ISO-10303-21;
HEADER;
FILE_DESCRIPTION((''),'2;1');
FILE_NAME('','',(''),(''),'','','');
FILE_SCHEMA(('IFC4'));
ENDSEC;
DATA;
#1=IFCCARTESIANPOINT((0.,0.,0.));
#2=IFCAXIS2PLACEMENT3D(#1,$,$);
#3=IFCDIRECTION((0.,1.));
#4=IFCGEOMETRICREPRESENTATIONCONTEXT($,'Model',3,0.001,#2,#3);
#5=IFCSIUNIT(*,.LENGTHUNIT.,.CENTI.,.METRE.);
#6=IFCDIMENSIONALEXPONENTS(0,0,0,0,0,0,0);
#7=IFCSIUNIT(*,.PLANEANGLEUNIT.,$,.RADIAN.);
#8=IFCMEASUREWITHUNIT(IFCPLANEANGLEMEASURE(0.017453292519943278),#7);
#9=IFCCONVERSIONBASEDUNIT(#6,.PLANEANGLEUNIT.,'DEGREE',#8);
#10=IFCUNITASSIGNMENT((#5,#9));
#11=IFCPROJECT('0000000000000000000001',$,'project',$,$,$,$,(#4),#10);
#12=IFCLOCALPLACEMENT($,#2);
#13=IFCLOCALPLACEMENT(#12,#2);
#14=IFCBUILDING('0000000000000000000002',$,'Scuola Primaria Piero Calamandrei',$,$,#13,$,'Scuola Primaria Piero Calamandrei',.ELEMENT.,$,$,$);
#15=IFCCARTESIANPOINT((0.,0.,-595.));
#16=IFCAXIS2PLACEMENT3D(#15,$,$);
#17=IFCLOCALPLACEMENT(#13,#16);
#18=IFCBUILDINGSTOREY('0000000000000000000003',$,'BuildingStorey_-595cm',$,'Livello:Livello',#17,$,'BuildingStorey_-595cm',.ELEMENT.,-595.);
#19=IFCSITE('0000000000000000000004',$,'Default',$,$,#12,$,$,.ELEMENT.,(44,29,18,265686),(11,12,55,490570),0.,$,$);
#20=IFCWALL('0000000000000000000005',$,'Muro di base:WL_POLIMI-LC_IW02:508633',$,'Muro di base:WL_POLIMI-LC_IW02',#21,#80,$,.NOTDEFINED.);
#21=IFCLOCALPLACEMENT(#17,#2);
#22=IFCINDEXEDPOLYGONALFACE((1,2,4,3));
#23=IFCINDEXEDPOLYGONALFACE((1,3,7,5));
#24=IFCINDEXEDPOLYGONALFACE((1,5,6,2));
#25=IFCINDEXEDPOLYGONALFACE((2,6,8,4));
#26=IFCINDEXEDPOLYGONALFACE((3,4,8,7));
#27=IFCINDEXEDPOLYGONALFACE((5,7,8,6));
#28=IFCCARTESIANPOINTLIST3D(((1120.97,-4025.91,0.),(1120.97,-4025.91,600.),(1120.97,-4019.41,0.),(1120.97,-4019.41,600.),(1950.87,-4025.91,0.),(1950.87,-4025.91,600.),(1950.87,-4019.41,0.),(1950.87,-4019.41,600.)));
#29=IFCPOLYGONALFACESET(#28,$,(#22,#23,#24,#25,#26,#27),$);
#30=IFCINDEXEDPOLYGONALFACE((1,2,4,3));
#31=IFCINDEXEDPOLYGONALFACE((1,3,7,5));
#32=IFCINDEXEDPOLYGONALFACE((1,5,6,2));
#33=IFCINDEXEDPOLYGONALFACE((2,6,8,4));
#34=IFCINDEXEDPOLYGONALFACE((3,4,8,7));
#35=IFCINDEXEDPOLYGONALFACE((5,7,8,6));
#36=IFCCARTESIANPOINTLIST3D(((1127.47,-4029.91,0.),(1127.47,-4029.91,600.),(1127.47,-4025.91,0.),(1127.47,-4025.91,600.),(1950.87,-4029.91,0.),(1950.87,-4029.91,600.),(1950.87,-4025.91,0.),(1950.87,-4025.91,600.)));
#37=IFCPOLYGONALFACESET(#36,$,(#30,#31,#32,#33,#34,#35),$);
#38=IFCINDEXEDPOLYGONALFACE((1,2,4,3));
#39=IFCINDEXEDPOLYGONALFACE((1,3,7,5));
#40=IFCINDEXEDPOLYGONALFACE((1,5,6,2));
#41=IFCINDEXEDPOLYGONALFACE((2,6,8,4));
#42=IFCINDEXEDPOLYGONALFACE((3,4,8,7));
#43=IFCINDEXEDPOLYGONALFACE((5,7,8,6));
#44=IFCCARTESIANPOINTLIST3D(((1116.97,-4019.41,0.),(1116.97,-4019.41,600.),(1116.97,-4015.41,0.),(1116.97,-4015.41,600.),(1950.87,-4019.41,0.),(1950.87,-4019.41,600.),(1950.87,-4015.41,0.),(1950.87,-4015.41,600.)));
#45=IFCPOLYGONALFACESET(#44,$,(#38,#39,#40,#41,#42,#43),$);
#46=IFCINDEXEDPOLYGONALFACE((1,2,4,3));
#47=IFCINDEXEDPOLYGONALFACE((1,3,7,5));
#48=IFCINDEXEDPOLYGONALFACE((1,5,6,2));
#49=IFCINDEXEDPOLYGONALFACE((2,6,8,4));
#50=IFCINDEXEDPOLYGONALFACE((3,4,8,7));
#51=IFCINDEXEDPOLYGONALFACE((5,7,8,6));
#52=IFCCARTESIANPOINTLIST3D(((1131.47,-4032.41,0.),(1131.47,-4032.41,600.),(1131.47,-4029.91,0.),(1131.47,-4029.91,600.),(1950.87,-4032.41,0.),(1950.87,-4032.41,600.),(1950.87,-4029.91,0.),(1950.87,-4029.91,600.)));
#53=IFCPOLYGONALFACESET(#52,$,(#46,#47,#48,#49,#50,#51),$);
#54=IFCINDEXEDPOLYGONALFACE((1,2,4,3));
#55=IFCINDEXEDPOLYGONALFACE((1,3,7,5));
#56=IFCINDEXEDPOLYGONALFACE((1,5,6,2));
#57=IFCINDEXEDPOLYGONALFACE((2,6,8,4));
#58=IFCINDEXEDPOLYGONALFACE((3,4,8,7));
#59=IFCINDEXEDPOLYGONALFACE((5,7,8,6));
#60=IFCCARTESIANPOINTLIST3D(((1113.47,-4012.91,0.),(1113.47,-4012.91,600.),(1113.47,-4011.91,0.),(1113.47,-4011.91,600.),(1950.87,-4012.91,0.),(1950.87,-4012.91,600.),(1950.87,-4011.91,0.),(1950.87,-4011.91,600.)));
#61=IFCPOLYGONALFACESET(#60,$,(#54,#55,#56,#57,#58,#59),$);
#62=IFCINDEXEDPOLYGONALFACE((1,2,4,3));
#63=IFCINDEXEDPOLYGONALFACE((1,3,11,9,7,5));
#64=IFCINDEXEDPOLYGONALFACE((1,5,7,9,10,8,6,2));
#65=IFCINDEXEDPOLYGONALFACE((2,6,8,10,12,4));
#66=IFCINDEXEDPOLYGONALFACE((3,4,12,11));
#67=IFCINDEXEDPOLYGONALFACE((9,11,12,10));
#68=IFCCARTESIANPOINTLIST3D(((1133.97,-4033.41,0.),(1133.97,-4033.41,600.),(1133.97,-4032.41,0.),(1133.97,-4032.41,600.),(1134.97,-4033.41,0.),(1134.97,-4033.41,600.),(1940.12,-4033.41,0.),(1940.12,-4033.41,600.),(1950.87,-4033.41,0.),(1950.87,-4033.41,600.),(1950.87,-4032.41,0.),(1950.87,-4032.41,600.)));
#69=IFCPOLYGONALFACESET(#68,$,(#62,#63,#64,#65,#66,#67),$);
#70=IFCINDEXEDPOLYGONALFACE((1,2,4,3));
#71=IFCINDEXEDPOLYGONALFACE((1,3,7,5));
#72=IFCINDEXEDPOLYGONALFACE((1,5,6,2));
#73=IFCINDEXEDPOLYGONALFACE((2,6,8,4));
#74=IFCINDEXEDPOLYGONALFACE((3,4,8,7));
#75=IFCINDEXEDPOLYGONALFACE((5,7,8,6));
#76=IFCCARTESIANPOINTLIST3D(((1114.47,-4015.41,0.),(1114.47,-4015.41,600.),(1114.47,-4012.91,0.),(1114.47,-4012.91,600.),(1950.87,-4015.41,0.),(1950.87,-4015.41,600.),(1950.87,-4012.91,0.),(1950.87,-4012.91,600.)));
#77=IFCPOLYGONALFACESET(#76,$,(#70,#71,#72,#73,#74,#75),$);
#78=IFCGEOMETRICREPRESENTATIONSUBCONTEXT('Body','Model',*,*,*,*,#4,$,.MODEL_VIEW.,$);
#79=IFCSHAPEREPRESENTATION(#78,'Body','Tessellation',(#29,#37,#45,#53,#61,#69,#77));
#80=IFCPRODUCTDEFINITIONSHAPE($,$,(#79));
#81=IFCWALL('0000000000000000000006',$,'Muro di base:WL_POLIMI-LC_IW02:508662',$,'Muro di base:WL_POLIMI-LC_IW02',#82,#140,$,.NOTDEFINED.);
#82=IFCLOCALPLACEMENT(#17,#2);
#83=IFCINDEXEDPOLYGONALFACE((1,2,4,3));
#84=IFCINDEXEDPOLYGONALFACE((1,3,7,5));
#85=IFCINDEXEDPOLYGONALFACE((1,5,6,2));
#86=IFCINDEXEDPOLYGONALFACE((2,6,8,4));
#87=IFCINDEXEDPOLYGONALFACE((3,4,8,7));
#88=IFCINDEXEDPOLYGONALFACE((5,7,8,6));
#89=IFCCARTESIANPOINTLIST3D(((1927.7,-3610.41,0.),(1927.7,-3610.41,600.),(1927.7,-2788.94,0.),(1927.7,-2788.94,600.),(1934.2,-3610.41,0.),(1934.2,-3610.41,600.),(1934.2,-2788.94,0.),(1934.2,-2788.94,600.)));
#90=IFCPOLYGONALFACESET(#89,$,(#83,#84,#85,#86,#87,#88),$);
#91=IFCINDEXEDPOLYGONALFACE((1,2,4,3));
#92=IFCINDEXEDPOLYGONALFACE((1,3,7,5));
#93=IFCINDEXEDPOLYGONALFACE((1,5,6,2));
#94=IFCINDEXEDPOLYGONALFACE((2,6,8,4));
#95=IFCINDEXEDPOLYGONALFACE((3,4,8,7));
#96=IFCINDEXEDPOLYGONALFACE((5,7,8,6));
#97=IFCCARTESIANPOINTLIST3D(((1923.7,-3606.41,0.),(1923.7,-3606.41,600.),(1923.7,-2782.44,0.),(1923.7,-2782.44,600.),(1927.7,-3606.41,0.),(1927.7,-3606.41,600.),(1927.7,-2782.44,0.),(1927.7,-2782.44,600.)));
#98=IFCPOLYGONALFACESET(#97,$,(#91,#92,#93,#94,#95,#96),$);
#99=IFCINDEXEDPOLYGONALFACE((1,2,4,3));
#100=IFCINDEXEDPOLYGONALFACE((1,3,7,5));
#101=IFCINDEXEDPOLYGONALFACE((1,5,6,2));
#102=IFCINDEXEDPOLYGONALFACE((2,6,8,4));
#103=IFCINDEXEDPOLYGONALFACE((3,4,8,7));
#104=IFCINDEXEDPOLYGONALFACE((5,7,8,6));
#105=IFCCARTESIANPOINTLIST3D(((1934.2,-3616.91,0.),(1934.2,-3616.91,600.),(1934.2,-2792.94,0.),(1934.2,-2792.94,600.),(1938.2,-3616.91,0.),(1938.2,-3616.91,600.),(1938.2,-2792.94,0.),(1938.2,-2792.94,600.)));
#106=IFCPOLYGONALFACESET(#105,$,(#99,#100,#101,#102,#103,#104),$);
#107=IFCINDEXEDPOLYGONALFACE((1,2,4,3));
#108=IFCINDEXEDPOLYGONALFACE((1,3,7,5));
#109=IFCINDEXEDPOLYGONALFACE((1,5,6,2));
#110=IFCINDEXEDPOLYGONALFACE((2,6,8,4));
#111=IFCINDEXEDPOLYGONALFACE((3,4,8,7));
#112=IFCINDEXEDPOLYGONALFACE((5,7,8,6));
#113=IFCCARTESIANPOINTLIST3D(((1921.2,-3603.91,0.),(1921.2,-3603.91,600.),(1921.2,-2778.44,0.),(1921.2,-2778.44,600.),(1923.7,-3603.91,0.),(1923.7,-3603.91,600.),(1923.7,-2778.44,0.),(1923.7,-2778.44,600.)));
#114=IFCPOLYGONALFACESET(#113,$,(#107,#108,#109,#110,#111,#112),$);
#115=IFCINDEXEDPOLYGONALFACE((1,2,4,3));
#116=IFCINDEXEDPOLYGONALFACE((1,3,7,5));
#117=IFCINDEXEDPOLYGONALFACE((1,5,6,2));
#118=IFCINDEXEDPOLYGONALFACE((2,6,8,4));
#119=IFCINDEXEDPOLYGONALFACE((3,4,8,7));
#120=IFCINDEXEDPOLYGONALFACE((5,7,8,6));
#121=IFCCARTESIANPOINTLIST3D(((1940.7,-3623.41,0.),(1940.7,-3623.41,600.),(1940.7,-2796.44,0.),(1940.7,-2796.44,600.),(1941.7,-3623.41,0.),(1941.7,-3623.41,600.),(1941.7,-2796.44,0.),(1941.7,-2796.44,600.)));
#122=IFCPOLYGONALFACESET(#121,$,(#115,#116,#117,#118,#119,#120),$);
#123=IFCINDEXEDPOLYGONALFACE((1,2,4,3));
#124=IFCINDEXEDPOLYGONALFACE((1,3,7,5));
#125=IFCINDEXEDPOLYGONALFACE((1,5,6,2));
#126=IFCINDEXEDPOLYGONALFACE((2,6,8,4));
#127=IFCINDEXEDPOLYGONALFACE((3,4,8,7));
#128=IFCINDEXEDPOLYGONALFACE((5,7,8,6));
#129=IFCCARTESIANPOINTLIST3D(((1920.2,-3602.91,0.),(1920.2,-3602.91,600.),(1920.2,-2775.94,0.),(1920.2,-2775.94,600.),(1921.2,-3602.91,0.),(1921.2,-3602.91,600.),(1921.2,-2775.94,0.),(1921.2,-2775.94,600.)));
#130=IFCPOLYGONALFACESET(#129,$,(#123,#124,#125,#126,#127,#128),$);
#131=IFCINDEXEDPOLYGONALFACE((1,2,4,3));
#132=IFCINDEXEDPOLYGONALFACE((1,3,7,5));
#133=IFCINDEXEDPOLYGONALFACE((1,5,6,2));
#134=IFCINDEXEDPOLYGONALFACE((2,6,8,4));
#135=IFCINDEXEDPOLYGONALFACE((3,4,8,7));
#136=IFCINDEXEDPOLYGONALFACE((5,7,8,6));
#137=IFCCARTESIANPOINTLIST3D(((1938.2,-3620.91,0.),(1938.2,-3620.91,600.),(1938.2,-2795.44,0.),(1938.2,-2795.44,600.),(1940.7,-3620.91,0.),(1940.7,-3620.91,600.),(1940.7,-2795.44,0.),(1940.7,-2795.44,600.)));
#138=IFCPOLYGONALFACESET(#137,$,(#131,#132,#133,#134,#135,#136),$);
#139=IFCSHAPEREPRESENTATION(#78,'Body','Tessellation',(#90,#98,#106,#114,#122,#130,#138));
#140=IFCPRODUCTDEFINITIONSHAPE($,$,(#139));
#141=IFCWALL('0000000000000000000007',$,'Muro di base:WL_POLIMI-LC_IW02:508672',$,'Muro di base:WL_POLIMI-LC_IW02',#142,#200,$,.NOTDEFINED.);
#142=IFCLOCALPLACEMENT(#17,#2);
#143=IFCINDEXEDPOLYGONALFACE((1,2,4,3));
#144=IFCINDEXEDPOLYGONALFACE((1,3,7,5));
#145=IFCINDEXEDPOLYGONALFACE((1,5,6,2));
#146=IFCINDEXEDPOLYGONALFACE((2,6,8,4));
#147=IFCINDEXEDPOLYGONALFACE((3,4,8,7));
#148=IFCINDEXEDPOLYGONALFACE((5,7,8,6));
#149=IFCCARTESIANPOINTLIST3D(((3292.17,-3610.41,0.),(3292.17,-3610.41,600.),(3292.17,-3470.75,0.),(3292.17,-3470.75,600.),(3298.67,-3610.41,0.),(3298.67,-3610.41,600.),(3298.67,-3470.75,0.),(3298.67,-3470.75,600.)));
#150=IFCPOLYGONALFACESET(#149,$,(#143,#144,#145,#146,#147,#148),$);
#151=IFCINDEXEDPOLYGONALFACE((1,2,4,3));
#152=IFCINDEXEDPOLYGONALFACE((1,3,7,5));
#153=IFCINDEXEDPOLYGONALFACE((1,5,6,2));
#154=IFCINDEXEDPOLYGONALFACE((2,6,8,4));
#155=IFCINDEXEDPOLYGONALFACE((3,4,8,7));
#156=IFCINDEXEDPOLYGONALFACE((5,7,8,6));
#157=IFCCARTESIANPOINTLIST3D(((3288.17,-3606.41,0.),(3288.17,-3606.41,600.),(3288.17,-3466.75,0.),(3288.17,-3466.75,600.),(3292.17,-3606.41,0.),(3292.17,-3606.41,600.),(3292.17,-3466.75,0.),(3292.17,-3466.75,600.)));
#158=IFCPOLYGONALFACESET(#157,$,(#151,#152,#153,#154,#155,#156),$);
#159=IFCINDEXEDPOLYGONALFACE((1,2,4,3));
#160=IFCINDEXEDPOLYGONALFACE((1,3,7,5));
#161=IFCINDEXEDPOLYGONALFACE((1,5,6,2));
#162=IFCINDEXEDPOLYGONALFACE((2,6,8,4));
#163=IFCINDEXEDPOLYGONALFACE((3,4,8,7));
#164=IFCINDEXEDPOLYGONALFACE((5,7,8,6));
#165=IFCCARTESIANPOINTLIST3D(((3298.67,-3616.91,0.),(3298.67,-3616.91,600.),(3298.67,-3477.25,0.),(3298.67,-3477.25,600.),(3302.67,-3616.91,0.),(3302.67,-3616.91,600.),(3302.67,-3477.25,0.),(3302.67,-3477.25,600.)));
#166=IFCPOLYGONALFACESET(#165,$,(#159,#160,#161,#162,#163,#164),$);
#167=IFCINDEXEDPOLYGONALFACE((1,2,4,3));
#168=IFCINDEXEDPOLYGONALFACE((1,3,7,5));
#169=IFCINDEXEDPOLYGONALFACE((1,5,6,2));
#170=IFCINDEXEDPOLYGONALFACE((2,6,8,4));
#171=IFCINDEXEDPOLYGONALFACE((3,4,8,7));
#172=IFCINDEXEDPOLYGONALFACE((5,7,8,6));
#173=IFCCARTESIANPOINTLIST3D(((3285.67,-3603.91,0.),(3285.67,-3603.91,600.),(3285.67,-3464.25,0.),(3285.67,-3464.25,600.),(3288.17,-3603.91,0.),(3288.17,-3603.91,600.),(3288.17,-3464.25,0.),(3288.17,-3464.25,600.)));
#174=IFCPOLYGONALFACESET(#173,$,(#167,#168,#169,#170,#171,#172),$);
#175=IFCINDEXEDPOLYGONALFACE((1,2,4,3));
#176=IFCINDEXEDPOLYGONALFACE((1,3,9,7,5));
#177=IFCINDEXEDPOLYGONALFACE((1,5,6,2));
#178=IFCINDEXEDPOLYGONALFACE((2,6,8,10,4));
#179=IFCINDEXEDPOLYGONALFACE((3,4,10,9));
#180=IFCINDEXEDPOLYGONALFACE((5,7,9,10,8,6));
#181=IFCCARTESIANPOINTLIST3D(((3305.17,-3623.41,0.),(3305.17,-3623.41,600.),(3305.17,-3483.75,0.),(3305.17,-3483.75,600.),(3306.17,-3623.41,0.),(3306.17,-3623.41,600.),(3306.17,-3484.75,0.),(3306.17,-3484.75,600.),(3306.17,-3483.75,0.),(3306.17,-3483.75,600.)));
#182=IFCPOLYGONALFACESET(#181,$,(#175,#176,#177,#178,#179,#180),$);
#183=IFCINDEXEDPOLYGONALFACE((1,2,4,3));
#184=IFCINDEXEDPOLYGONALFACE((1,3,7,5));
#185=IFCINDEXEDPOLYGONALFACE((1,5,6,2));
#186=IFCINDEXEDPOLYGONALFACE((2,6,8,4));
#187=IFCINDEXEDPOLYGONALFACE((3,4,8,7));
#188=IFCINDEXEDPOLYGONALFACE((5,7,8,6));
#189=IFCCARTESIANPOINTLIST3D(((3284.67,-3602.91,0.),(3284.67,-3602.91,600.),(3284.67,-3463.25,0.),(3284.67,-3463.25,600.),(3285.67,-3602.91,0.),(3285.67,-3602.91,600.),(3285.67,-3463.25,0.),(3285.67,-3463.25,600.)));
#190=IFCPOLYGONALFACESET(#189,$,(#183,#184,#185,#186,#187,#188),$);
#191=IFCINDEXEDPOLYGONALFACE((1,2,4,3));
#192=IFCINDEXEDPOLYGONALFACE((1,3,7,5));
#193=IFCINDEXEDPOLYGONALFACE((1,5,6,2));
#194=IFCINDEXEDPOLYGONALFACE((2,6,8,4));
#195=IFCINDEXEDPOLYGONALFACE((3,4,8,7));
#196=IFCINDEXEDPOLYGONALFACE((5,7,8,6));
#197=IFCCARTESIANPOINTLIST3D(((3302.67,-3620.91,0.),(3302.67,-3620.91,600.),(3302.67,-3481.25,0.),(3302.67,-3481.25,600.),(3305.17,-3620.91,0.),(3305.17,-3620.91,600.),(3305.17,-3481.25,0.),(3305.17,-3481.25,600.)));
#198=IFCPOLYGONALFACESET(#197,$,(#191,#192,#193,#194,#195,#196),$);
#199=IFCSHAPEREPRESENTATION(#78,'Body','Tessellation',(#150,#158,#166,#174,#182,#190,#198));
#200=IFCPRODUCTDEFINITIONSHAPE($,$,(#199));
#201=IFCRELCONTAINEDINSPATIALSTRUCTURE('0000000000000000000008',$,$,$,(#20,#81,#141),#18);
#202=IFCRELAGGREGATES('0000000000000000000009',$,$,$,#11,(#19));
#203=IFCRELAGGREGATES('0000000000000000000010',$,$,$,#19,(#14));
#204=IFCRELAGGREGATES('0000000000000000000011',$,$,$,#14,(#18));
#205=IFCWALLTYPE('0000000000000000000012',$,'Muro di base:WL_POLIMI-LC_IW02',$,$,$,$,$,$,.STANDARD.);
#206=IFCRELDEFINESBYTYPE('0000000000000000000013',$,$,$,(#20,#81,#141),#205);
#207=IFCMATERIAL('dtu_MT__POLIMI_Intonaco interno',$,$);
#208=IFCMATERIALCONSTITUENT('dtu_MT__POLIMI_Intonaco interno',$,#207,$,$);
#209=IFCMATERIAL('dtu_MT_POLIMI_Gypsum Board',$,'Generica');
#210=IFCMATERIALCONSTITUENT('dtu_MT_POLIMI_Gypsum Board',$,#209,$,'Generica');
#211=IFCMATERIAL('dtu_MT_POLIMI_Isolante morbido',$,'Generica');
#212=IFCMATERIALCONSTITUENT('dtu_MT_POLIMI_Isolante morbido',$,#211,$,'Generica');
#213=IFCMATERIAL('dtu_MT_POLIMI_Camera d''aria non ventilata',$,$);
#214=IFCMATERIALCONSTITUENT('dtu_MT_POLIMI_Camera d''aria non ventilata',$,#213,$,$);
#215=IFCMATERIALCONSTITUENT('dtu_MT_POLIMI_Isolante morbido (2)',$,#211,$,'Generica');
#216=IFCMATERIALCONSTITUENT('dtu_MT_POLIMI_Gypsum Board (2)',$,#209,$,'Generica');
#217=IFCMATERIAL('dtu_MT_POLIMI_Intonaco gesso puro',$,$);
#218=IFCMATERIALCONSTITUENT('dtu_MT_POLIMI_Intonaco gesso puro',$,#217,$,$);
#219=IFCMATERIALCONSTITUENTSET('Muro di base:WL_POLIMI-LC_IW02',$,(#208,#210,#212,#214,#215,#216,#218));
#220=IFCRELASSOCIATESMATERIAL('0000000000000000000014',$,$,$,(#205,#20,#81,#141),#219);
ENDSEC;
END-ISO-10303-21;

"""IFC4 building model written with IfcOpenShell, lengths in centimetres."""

from ifc_helpers import new_model, entity, si_unit, converted_unit, direction, frame, origin, place, context, subcontext, project, spatial, indexed_curve, outline, extrude, material, constituent, constituent_set, type_object, element, save


model = new_model("IFC4")

# Units and contexts
model_context = context("Model", 3, precision=0.001, world=origin(), true_north=direction((0.0, 1.0)))
body_context = subcontext(model_context, "Body", "Model", "MODEL_VIEW")
ifc_project = project(units=[si_unit("LENGTHUNIT", "METRE", prefix="CENTI"), converted_unit("PLANEANGLEUNIT", "DEGREE", entity("IfcPlaneAngleMeasure", 0.017453292519943278), si_unit("PLANEANGLEUNIT", "RADIAN"), dimensions=[0, 0, 0, 0, 0, 0, 0])], contexts=[model_context])

# Site, building, storey
site_placement = place(None, origin())
site = spatial("IfcSite", under=ifc_project, at=site_placement, Name="Default", CompositionType="ELEMENT", RefLatitude=(44, 29, 18, 265686), RefLongitude=(11, 12, 55, 490570), RefElevation=0.0)
building_placement = place(site_placement, origin())
building = spatial("IfcBuilding", under=site, at=building_placement, Name="Scuola Primaria Piero Calamandrei", LongName="Scuola Primaria Piero Calamandrei", CompositionType="ELEMENT")
storey_placement = place(building_placement, frame((0.0, 0.0, -595.0)))
storey = spatial("IfcBuildingStorey", under=building, at=storey_placement, Name="BuildingStorey_-595cm", ObjectType="Livello:Livello", LongName="BuildingStorey_-595cm", CompositionType="ELEMENT", Elevation=-595.0)

# Shared definitions
ifc_material_1 = material(Name="dtu_MT__POLIMI_Intonaco interno")
ifc_constituent_1 = constituent(ifc_material_1, Name="dtu_MT__POLIMI_Intonaco interno")
ifc_material_2 = material(Name="dtu_MT_POLIMI_Gypsum Board", Category="Generica")
ifc_constituent_2 = constituent(ifc_material_2, Name="dtu_MT_POLIMI_Gypsum Board", Category="Generica")
ifc_material_3 = material(Name="dtu_MT_POLIMI_Isolante morbido", Category="Generica")
ifc_constituent_3 = constituent(ifc_material_3, Name="dtu_MT_POLIMI_Isolante morbido", Category="Generica")
ifc_material_4 = material(Name="dtu_MT_POLIMI_Camera d'aria non ventilata")
ifc_constituent_4 = constituent(ifc_material_4, Name="dtu_MT_POLIMI_Camera d'aria non ventilata")
ifc_constituent_5 = constituent(ifc_material_3, Name="dtu_MT_POLIMI_Isolante morbido (2)", Category="Generica")
ifc_constituent_6 = constituent(ifc_material_2, Name="dtu_MT_POLIMI_Gypsum Board (2)", Category="Generica")
ifc_material_5 = material(Name="dtu_MT_POLIMI_Intonaco gesso puro")
ifc_constituent_7 = constituent(ifc_material_5, Name="dtu_MT_POLIMI_Intonaco gesso puro")
ifc_constituent_set_1 = constituent_set(constituents=[ifc_constituent_1, ifc_constituent_2, ifc_constituent_3, ifc_constituent_4, ifc_constituent_5, ifc_constituent_6, ifc_constituent_7], Name="Muro di base:WL_POLIMI-LC_IW02")
wall_type_1 = type_object("IfcWallType", Name="Muro di base:WL_POLIMI-LC_IW02", PredefinedType="STANDARD", material=ifc_constituent_set_1)

# Walls
wall_1_placement = place(storey_placement, frame((1950.87, -4022.66, 0.0), z_axis=(0.0, 0.0, 1.0), x_axis=(-1.0, 0.0, 0.0)))
element("IfcWall", 1, at=wall_1_placement, inside=storey, type_object=wall_type_1, material=ifc_constituent_set_1, Name="Muro di base:WL_POLIMI-LC_IW02:508633", ObjectType="Muro di base:WL_POLIMI-LC_IW02", PredefinedType="NOTDEFINED", context=body_context, shape_type="SweptSolid", body=[
    extrude(outline(indexed_curve([(-414.95, -3.25), (414.95, -3.25), (414.95, 3.25), (-414.95, 3.25), (-414.95, -3.25)], self_intersect=False)), frame((414.95, 0.0, 0.0)), (0.0, 0.0, 1.0), 600.0),
    extrude(outline(indexed_curve([(-411.7, -2.0), (411.7, -2.0), (411.7, 2.0), (-411.7, 2.0), (-411.7, -2.0)], self_intersect=False)), frame((411.7, 5.25, 0.0)), (0.0, 0.0, 1.0), 600.0),
    extrude(outline(indexed_curve([(-416.95, -2.0), (416.95, -2.0), (416.95, 2.0), (-416.95, 2.0), (-416.95, -2.0)], self_intersect=False)), frame((416.95, -5.25, 0.0)), (0.0, 0.0, 1.0), 600.0),
    extrude(outline(indexed_curve([(-409.7, -1.25), (409.7, -1.25), (409.7, 1.25), (-409.7, 1.25), (-409.7, -1.25)], self_intersect=False)), frame((409.7, 8.5, 0.0)), (0.0, 0.0, 1.0), 600.0),
    extrude(outline(indexed_curve([(-0.5, -418.7), (0.5, -418.7), (0.5, 418.7), (-0.5, 418.7), (-0.5, -418.7)], self_intersect=False)), frame((418.7, -10.25, 0.0), z_axis=(0.0, 0.0, 1.0), x_axis=(0.0, 1.0, 0.0)), (0.0, 0.0, 1.0), 600.0),
    extrude(outline(indexed_curve([(-405.82, -0.33), (399.32, -0.33), (410.07, -0.33), (410.07, 0.67), (-406.82, 0.67), (-406.82, -0.33), (-405.82, -0.33)], self_intersect=False)), frame((410.07, 10.42, 0.0), z_axis=(0.0, 0.0, 1.0), x_axis=(-1.0, 0.0, 0.0)), (0.0, 0.0, 1.0), 600.0),
    extrude(outline(indexed_curve([(-418.2, -1.25), (418.2, -1.25), (418.2, 1.25), (-418.2, 1.25), (-418.2, -1.25)], self_intersect=False)), frame((418.2, -8.5, 0.0)), (0.0, 0.0, 1.0), 600.0),
])
wall_2_placement = place(storey_placement, frame((1930.95, -3602.91, 0.0), z_axis=(0.0, 0.0, 1.0), x_axis=(0.0, 1.0, 0.0)))
element("IfcWall", 2, at=wall_2_placement, inside=storey, type_object=wall_type_1, material=ifc_constituent_set_1, Name="Muro di base:WL_POLIMI-LC_IW02:508662", ObjectType="Muro di base:WL_POLIMI-LC_IW02", PredefinedType="NOTDEFINED", context=body_context, shape_type="SweptSolid", body=[
    extrude(outline(indexed_curve([(-410.74, -3.25), (410.74, -3.25), (410.74, 3.25), (-410.74, 3.25), (-410.74, -3.25)], self_intersect=False)), frame((403.24, 0.0, 0.0)), (0.0, 0.0, 1.0), 600.0),
    extrude(outline(indexed_curve([(-411.99, -2.0), (411.99, -2.0), (411.99, 2.0), (-411.99, 2.0), (-411.99, -2.0)], self_intersect=False)), frame((408.49, 5.25, 0.0)), (0.0, 0.0, 1.0), 600.0),
    extrude(outline(indexed_curve([(-411.99, -2.0), (411.99, -2.0), (411.99, 2.0), (-411.99, 2.0), (-411.99, -2.0)], self_intersect=False)), frame((397.99, -5.25, 0.0)), (0.0, 0.0, 1.0), 600.0),
    extrude(outline(indexed_curve([(-412.74, -1.25), (412.74, -1.25), (412.74, 1.25), (-412.74, 1.25), (-412.74, -1.25)], self_intersect=False)), frame((411.74, 8.5, 0.0)), (0.0, 0.0, 1.0), 600.0),
    extrude(outline(indexed_curve([(-0.5, -413.49), (0.5, -413.49), (0.5, 413.49), (-0.5, 413.49), (-0.5, -413.49)], self_intersect=False)), frame((392.99, -10.25, 0.0), z_axis=(0.0, 0.0, 1.0), x_axis=(0.0, 1.0, 0.0)), (0.0, 0.0, 1.0), 600.0),
    extrude(outline(indexed_curve([(-0.5, -413.49), (0.5, -413.49), (0.5, 413.49), (-0.5, 413.49), (-0.5, -413.49)], self_intersect=False)), frame((413.49, 10.25, 0.0), z_axis=(0.0, 0.0, 1.0), x_axis=(0.0, -1.0, 0.0)), (0.0, 0.0, 1.0), 600.0),
    extrude(outline(indexed_curve([(-412.74, -1.25), (412.74, -1.25), (412.74, 1.25), (-412.74, 1.25), (-412.74, -1.25)], self_intersect=False)), frame((394.74, -8.5, 0.0)), (0.0, 0.0, 1.0), 600.0),
])
wall_3_placement = place(storey_placement, frame((3295.42, -3602.91, 0.0), z_axis=(0.0, 0.0, 1.0), x_axis=(0.0, 1.0, 0.0)))
element("IfcWall", 3, at=wall_3_placement, inside=storey, type_object=wall_type_1, material=ifc_constituent_set_1, Name="Muro di base:WL_POLIMI-LC_IW02:508672", ObjectType="Muro di base:WL_POLIMI-LC_IW02", PredefinedType="NOTDEFINED", context=body_context, shape_type="SweptSolid", body=[
    extrude(outline(indexed_curve([(-69.83, -3.25), (69.83, -3.25), (69.83, 3.25), (-69.83, 3.25), (-69.83, -3.25)], self_intersect=False)), frame((62.33, 0.0, 0.0)), (0.0, 0.0, 1.0), 600.0),
    extrude(outline(indexed_curve([(-69.83, -2.0), (69.83, -2.0), (69.83, 2.0), (-69.83, 2.0), (-69.83, -2.0)], self_intersect=False)), frame((66.33, 5.25, 0.0)), (0.0, 0.0, 1.0), 600.0),
    extrude(outline(indexed_curve([(-69.83, -2.0), (69.83, -2.0), (69.83, 2.0), (-69.83, 2.0), (-69.83, -2.0)], self_intersect=False)), frame((55.83, -5.25, 0.0)), (0.0, 0.0, 1.0), 600.0),
    extrude(outline(indexed_curve([(-69.83, -1.25), (69.83, -1.25), (69.83, 1.25), (-69.83, 1.25), (-69.83, -1.25)], self_intersect=False)), frame((68.83, 8.5, 0.0)), (0.0, 0.0, 1.0), 600.0),
    extrude(outline(indexed_curve([(55.06, -0.4), (56.06, -0.4), (56.06, 0.6), (-83.59, 0.6), (-83.59, -0.4), (55.06, -0.4)], self_intersect=False)), frame((63.09, -10.35, 0.0)), (0.0, 0.0, 1.0), 600.0),
    extrude(outline(indexed_curve([(-0.5, -69.83), (0.5, -69.83), (0.5, 69.83), (-0.5, 69.83), (-0.5, -69.83)], self_intersect=False)), frame((69.83, 10.25, 0.0), z_axis=(0.0, 0.0, 1.0), x_axis=(0.0, -1.0, 0.0)), (0.0, 0.0, 1.0), 600.0),
    extrude(outline(indexed_curve([(-69.83, -1.25), (69.83, -1.25), (69.83, 1.25), (-69.83, 1.25), (-69.83, -1.25)], self_intersect=False)), frame((51.83, -8.5, 0.0)), (0.0, 0.0, 1.0), 600.0),
])

save(model, "model.ifc")
